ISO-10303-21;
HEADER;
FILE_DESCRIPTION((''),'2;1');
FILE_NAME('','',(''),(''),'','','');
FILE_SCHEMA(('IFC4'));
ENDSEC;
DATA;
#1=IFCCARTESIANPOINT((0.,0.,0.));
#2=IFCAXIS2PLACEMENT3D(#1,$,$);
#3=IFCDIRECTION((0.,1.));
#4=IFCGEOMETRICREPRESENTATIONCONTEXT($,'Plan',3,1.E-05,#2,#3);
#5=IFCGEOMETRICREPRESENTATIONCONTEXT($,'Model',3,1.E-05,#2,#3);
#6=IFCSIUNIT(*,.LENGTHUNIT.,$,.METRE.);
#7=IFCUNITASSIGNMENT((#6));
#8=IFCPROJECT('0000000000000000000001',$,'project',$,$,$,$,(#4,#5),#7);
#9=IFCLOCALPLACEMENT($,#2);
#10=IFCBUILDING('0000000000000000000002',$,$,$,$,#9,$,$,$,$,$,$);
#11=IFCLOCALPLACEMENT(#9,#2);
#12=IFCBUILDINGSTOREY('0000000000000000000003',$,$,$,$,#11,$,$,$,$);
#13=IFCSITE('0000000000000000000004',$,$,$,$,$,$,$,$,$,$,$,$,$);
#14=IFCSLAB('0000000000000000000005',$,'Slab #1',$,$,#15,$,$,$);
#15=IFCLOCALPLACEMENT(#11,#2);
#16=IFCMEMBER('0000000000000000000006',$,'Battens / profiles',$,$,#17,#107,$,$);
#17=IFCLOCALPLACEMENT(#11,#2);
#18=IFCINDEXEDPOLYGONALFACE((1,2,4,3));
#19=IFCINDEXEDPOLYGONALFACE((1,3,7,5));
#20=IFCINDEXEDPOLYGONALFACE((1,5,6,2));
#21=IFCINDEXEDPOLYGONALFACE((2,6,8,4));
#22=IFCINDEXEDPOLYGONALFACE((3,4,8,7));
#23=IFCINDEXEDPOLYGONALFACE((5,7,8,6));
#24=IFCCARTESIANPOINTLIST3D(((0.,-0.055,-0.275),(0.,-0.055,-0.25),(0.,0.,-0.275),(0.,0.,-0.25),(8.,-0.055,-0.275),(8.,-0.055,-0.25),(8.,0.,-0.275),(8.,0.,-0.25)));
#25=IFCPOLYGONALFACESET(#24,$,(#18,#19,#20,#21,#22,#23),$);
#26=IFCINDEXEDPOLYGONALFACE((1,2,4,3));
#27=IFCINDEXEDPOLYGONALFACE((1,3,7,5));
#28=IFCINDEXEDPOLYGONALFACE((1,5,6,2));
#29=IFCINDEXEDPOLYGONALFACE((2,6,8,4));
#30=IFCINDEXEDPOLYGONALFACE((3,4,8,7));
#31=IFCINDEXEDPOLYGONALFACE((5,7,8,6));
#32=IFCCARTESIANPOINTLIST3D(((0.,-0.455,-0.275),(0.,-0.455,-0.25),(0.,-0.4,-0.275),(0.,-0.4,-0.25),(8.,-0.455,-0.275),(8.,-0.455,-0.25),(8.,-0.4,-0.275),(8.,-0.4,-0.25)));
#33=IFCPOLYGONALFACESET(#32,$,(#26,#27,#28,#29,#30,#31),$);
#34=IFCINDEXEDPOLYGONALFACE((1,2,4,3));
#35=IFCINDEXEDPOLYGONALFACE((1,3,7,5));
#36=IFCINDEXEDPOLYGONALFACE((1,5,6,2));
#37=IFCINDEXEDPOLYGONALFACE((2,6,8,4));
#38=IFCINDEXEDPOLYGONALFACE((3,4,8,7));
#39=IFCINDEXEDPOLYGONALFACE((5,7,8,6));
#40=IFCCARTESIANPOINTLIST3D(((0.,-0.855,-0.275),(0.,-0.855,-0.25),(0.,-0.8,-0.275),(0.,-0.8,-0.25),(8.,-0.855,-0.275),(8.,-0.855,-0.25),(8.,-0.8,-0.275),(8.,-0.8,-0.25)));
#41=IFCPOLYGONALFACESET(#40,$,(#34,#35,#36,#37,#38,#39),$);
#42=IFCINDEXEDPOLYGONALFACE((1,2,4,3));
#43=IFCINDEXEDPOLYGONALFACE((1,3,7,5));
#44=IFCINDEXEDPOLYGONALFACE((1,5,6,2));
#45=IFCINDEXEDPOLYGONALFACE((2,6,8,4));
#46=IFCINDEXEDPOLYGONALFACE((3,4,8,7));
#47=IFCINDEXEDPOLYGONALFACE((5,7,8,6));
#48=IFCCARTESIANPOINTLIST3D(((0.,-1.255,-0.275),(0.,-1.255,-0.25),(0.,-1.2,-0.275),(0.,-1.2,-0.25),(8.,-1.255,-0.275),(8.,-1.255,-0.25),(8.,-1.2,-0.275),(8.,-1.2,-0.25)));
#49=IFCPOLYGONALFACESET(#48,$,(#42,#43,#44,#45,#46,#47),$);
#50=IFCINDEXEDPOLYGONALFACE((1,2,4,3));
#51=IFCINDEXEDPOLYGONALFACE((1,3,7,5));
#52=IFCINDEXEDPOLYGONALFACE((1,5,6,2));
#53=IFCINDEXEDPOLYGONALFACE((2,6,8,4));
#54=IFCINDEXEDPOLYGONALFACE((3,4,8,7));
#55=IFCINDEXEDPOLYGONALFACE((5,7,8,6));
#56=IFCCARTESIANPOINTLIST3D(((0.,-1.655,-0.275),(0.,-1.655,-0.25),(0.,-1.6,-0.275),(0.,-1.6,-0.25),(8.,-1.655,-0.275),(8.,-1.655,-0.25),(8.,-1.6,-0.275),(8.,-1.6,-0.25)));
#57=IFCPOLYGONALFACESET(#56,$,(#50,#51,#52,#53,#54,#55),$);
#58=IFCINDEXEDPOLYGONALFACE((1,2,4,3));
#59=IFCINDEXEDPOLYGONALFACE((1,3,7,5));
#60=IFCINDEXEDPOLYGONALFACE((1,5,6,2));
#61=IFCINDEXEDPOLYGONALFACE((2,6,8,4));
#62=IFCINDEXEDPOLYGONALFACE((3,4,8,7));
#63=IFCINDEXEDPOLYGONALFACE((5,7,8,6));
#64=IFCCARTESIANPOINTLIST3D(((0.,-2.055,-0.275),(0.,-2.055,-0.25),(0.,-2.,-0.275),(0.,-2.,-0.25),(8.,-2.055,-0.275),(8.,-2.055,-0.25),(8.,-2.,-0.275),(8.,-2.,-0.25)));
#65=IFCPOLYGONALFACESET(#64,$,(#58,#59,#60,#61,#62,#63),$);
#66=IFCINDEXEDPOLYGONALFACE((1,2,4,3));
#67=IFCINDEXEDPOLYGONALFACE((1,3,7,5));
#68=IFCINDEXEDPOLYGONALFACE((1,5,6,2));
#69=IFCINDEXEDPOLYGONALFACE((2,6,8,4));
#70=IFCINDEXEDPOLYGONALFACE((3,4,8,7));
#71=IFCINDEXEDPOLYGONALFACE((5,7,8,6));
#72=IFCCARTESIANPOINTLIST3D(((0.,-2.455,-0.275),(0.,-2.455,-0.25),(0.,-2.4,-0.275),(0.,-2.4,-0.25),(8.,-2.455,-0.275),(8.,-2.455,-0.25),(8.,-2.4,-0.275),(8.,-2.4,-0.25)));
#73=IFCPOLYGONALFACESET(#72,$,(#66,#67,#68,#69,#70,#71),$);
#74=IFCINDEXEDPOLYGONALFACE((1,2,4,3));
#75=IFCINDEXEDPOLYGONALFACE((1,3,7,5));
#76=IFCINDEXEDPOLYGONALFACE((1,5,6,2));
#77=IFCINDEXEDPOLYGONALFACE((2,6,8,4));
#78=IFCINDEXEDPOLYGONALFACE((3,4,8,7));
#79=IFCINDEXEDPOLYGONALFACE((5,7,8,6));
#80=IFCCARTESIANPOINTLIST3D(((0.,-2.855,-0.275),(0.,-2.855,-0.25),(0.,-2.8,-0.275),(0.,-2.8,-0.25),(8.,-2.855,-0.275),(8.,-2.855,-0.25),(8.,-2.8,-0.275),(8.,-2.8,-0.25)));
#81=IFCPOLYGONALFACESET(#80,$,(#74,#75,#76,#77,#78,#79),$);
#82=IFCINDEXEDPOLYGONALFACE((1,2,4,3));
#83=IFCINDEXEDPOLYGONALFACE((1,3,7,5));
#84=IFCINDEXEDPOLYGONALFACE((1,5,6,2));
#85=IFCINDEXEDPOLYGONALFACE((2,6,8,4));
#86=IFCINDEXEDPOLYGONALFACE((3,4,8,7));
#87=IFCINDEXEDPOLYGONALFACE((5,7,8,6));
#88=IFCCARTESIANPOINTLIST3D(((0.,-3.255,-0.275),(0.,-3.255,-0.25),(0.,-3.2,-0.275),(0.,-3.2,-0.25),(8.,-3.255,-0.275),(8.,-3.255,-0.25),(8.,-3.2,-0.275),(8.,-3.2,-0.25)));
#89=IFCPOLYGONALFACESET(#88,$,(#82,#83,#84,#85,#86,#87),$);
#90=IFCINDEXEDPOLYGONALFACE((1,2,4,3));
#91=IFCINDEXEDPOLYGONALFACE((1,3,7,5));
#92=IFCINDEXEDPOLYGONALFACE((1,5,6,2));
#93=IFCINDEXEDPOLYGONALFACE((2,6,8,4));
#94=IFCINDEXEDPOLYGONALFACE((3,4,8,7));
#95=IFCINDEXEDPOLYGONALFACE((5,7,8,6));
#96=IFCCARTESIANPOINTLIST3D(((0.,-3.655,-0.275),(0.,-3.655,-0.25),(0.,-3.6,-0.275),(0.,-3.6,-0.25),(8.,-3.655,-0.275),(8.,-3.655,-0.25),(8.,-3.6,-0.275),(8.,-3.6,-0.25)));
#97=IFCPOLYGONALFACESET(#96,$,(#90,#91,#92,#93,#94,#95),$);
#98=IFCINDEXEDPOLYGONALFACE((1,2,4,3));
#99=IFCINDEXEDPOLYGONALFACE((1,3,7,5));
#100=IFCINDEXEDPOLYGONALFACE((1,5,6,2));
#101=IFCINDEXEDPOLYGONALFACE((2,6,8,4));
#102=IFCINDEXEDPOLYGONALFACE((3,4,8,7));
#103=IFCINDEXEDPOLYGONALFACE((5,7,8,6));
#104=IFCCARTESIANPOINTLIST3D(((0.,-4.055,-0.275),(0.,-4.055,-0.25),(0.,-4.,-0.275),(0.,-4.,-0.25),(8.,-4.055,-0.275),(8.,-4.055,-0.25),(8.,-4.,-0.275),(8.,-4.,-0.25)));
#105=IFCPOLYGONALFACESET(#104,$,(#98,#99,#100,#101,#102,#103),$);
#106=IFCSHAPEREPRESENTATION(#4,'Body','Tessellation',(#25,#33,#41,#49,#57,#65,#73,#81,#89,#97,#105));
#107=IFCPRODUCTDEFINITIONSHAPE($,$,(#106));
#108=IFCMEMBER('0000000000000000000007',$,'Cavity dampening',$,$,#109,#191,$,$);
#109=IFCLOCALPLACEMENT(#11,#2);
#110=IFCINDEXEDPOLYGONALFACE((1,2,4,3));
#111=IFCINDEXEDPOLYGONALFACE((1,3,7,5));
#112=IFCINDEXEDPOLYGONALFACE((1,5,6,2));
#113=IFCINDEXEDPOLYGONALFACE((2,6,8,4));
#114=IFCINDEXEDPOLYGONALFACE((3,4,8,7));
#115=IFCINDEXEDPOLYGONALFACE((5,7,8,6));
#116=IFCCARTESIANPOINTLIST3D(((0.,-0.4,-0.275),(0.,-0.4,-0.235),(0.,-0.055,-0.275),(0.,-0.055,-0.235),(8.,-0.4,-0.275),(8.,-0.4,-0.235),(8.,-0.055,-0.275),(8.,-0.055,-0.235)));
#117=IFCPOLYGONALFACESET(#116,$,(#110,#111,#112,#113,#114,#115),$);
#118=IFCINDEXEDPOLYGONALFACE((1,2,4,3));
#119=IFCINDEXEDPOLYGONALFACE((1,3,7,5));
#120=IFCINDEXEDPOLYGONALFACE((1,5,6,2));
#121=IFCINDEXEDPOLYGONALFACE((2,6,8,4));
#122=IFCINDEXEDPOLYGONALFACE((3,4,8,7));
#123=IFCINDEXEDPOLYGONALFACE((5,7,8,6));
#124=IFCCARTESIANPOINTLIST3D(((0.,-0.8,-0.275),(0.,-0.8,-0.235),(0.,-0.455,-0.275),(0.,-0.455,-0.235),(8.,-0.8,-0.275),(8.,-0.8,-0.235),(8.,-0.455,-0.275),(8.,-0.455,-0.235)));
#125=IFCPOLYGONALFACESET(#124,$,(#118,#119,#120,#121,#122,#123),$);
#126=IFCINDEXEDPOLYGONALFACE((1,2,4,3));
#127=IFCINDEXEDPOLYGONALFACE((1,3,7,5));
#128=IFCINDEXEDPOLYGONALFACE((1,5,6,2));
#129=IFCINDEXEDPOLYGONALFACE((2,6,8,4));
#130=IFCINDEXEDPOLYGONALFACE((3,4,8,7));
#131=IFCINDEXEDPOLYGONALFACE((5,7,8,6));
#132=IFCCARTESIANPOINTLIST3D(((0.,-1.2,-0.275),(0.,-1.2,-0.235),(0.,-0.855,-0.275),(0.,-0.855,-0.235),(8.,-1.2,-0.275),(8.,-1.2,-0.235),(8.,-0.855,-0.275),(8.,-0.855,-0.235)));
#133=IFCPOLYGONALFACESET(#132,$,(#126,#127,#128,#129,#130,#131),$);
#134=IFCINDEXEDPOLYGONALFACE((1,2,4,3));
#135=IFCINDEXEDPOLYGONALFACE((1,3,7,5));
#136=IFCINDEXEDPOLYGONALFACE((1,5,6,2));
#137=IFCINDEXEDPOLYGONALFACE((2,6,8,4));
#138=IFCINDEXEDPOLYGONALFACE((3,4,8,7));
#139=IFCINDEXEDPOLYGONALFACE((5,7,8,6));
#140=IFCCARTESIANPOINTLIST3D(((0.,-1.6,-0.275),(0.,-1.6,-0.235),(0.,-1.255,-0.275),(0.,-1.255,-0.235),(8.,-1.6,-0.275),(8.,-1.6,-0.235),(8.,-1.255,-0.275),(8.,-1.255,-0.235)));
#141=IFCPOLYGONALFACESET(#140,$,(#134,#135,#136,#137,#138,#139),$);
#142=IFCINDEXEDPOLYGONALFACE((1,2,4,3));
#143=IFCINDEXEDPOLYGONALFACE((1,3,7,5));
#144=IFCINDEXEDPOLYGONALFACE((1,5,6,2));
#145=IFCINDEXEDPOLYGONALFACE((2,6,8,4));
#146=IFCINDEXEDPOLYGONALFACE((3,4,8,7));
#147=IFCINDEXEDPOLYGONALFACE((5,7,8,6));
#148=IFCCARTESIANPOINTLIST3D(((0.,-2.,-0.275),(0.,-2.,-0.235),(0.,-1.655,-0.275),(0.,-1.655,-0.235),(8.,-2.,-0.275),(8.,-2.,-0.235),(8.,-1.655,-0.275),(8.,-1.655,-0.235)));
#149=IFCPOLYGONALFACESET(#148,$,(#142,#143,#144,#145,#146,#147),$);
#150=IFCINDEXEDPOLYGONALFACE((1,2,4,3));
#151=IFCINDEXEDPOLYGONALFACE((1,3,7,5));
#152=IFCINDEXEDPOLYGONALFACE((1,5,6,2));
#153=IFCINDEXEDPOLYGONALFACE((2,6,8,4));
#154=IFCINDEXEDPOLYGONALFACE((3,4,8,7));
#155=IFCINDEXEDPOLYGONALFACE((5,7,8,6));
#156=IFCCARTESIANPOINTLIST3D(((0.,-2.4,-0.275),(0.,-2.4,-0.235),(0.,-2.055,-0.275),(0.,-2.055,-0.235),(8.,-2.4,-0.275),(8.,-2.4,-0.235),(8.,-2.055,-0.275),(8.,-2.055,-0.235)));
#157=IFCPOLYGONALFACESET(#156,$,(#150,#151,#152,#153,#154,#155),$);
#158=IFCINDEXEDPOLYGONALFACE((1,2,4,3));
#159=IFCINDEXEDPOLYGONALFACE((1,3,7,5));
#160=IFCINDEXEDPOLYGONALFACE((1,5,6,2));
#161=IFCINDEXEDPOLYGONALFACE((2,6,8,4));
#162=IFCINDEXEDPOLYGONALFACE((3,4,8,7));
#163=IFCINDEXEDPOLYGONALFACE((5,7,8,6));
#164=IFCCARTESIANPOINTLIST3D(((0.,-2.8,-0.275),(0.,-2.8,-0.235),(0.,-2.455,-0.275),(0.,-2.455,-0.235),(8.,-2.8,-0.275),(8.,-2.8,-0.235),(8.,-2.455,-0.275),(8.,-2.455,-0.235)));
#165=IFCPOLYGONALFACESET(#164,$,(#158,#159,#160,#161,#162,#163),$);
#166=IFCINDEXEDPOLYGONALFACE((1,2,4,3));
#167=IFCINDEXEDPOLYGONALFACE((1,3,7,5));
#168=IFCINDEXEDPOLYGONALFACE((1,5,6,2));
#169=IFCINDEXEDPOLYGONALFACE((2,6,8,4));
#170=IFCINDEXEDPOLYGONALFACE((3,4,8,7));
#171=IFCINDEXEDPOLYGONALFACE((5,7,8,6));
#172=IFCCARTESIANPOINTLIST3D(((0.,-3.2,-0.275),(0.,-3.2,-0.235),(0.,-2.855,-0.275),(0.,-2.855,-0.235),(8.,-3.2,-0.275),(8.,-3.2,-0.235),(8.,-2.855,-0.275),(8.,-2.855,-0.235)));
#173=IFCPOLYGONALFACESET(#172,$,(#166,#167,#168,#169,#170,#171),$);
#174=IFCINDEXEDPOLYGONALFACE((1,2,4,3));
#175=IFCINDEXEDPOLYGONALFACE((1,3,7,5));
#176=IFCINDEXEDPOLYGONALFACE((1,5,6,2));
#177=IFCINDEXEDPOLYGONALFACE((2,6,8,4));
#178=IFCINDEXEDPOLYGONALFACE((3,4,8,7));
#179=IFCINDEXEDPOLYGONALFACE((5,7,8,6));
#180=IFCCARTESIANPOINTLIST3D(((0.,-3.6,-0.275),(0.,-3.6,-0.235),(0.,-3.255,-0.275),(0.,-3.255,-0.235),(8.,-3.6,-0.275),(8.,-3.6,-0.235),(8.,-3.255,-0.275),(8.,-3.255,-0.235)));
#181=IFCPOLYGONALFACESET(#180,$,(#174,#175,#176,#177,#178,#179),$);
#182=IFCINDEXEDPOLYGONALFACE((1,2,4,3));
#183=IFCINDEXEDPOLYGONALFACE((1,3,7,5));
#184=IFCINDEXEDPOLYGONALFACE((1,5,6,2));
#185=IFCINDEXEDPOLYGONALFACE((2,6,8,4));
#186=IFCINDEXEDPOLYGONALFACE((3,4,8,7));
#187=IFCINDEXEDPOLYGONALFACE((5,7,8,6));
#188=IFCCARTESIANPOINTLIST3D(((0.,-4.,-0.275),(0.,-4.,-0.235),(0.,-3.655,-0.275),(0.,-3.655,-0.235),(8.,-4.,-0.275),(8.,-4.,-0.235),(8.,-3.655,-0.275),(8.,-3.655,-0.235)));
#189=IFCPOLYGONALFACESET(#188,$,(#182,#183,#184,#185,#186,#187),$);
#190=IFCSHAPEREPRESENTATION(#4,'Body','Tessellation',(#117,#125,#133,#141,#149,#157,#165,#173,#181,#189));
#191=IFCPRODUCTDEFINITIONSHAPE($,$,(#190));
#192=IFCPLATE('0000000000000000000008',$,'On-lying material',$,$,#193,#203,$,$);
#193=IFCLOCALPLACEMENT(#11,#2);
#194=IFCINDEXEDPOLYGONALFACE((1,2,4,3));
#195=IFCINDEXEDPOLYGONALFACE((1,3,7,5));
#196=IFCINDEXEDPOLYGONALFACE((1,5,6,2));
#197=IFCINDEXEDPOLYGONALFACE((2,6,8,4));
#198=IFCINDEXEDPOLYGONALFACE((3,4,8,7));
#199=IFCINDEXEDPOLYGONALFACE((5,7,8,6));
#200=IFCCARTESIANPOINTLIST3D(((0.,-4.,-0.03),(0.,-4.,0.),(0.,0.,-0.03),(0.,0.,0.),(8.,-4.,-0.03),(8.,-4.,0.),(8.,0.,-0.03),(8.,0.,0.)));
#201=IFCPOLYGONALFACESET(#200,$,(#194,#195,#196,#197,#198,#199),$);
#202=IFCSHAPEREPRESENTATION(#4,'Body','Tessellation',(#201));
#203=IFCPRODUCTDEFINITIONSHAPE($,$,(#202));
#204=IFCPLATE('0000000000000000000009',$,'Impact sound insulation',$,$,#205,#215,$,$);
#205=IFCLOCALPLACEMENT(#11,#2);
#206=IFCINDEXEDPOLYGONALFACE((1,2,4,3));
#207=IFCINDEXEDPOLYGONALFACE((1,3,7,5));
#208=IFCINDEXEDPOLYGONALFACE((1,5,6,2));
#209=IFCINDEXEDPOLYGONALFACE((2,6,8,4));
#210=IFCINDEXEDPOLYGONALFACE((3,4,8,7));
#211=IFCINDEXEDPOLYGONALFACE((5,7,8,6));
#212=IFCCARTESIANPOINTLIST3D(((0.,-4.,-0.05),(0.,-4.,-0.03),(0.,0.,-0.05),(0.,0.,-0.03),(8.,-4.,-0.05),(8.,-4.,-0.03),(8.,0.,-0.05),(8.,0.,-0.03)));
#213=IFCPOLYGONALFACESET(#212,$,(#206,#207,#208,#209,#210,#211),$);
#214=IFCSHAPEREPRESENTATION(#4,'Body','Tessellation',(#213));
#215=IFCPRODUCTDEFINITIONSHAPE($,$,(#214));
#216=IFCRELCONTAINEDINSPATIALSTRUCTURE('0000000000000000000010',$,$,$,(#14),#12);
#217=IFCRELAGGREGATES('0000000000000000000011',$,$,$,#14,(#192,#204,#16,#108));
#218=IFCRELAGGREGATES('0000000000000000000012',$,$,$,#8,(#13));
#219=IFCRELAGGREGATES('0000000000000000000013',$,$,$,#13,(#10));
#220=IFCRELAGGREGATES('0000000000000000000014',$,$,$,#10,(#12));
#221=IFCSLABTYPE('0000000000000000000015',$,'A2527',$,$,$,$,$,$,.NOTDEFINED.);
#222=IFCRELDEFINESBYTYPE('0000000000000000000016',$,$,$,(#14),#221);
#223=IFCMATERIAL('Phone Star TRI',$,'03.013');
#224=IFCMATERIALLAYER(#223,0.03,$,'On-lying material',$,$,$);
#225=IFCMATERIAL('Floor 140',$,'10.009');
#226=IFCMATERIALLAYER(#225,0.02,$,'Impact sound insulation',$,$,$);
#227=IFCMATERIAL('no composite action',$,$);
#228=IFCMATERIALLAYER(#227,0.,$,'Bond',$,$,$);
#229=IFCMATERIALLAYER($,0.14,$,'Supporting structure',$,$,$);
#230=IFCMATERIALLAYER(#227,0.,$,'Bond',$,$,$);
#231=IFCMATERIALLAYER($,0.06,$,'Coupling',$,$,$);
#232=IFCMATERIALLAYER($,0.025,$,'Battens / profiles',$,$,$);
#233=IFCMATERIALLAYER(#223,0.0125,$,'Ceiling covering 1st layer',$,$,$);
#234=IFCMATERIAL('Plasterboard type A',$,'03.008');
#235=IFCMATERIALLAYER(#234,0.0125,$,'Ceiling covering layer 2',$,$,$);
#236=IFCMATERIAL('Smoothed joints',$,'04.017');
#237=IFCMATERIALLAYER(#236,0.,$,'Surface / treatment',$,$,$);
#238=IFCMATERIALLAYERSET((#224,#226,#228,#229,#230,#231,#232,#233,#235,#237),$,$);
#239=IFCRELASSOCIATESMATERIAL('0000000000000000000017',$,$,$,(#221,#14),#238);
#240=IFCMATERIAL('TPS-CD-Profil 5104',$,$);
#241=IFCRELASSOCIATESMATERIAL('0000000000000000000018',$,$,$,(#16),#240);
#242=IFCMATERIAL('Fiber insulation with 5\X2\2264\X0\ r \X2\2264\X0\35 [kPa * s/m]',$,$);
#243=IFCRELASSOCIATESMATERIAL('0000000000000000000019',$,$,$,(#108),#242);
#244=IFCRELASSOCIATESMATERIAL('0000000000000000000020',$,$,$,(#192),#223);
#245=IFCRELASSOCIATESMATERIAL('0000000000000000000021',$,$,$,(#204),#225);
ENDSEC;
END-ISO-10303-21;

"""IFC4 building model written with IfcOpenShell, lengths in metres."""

from ifc_helpers import new_model, si_unit, direction, frame, frame_2d, origin, origin_with_axes, place, context, project, spatial, rectangle, extrude, material, layer, layer_set, type_object, element, aggregate, save


model = new_model("IFC4")

# Units and contexts
plan_context = context("Plan", 3, precision=1e-05, world=origin(), true_north=direction((0.0, 1.0)))
model_context = context("Model", 3, precision=1e-05, world=origin(), true_north=direction((0.0, 1.0)))
ifc_project = project(units=[si_unit("LENGTHUNIT", "METRE")], contexts=[plan_context, model_context])

# Site, building, storey
site = spatial("IfcSite", under=ifc_project)
building_placement = place(None, origin())
building = spatial("IfcBuilding", under=site, at=building_placement)
storey_placement = place(building_placement, origin())
storey = spatial("IfcBuildingStorey", under=building, at=storey_placement)

# Slab, members, plates
ifc_material_1 = material(Name="Phone Star TRI", Category="03.013")
ifc_layer_1 = layer(ifc_material_1, 0.03, Name="On-lying material")
ifc_material_2 = material(Name="Floor 140", Category="10.009")
ifc_layer_2 = layer(ifc_material_2, 0.02, Name="Impact sound insulation")
ifc_material_3 = material(Name="no composite action")
ifc_layer_3 = layer(ifc_material_3, 0.0, Name="Bond")
ifc_layer_4 = layer(None, 0.14, Name="Supporting structure")
ifc_layer_5 = layer(ifc_material_3, 0.0, Name="Bond")
ifc_layer_6 = layer(None, 0.06, Name="Coupling")
ifc_layer_7 = layer(None, 0.025, Name="Battens / profiles")
ifc_layer_8 = layer(ifc_material_1, 0.0125, Name="Ceiling covering 1st layer")
ifc_material_4 = material(Name="Plasterboard type A", Category="03.008")
ifc_layer_9 = layer(ifc_material_4, 0.0125, Name="Ceiling covering layer 2")
ifc_material_5 = material(Name="Smoothed joints", Category="04.017")
ifc_layer_10 = layer(ifc_material_5, 0.0, Name="Surface / treatment")
ifc_layer_set = layer_set([ifc_layer_1, ifc_layer_2, ifc_layer_3, ifc_layer_4, ifc_layer_5, ifc_layer_6, ifc_layer_7, ifc_layer_8, ifc_layer_9, ifc_layer_10])
slab_type = type_object("IfcSlabType", Name="A2527", PredefinedType="NOTDEFINED", material=ifc_layer_set)
slab_placement = place(None, frame((0.0, 0.0, 0.0), z_axis=(0.0, 0.0, -1.0), x_axis=(1.0, 0.0, 0.0)))
slab = element("IfcSlab", 1, at=slab_placement, inside=storey, type_object=slab_type, material=ifc_layer_set, Name="Slab #1")
ifc_material_6 = material(Name="TPS-CD-Profil 5104")
member_1_placement = place(slab_placement, origin())
member_1 = element("IfcMember", 2, at=member_1_placement, material=ifc_material_6, Name="Battens / profiles", context=plan_context, shape_type="SweptSolid", body=[
    extrude(rectangle(XDim=0.055, YDim=0.025, at=frame_2d((0.0275, 0.0125), x_axis=(1.0, 0.0))), frame((0.0, 0.0, 0.25), z_axis=(1.0, 0.0, 0.0), x_axis=(0.0, 1.0, 0.0)), (0.0, 0.0, 1.0), 8.0),
    extrude(rectangle(XDim=0.055, YDim=0.025, at=frame_2d((0.0275, 0.0125), x_axis=(1.0, 0.0))), frame((0.0, 0.4, 0.25), z_axis=(1.0, 0.0, 0.0), x_axis=(0.0, 1.0, 0.0)), (0.0, 0.0, 1.0), 8.0),
    extrude(rectangle(XDim=0.055, YDim=0.025, at=frame_2d((0.0275, 0.0125), x_axis=(1.0, 0.0))), frame((0.0, 0.8, 0.25), z_axis=(1.0, 0.0, 0.0), x_axis=(0.0, 1.0, 0.0)), (0.0, 0.0, 1.0), 8.0),
    extrude(rectangle(XDim=0.055, YDim=0.025, at=frame_2d((0.0275, 0.0125), x_axis=(1.0, 0.0))), frame((0.0, 1.2, 0.25), z_axis=(1.0, 0.0, 0.0), x_axis=(0.0, 1.0, 0.0)), (0.0, 0.0, 1.0), 8.0),
    extrude(rectangle(XDim=0.055, YDim=0.025, at=frame_2d((0.0275, 0.0125), x_axis=(1.0, 0.0))), frame((0.0, 1.6, 0.25), z_axis=(1.0, 0.0, 0.0), x_axis=(0.0, 1.0, 0.0)), (0.0, 0.0, 1.0), 8.0),
    extrude(rectangle(XDim=0.055, YDim=0.025, at=frame_2d((0.0275, 0.0125), x_axis=(1.0, 0.0))), frame((0.0, 2.0, 0.25), z_axis=(1.0, 0.0, 0.0), x_axis=(0.0, 1.0, 0.0)), (0.0, 0.0, 1.0), 8.0),
    extrude(rectangle(XDim=0.055, YDim=0.025, at=frame_2d((0.0275, 0.0125), x_axis=(1.0, 0.0))), frame((0.0, 2.4, 0.25), z_axis=(1.0, 0.0, 0.0), x_axis=(0.0, 1.0, 0.0)), (0.0, 0.0, 1.0), 8.0),
    extrude(rectangle(XDim=0.055, YDim=0.025, at=frame_2d((0.0275, 0.0125), x_axis=(1.0, 0.0))), frame((0.0, 2.8, 0.25), z_axis=(1.0, 0.0, 0.0), x_axis=(0.0, 1.0, 0.0)), (0.0, 0.0, 1.0), 8.0),
    extrude(rectangle(XDim=0.055, YDim=0.025, at=frame_2d((0.0275, 0.0125), x_axis=(1.0, 0.0))), frame((0.0, 3.2, 0.25), z_axis=(1.0, 0.0, 0.0), x_axis=(0.0, 1.0, 0.0)), (0.0, 0.0, 1.0), 8.0),
    extrude(rectangle(XDim=0.055, YDim=0.025, at=frame_2d((0.0275, 0.0125), x_axis=(1.0, 0.0))), frame((0.0, 3.6, 0.25), z_axis=(1.0, 0.0, 0.0), x_axis=(0.0, 1.0, 0.0)), (0.0, 0.0, 1.0), 8.0),
    extrude(rectangle(XDim=0.055, YDim=0.025, at=frame_2d((0.0275, 0.0125), x_axis=(1.0, 0.0))), frame((0.0, 4.0, 0.25), z_axis=(1.0, 0.0, 0.0), x_axis=(0.0, 1.0, 0.0)), (0.0, 0.0, 1.0), 8.0),
])
ifc_material_7 = material(Name="Fiber insulation with 5≤ r ≤35 [kPa * s/m]")
member_2_placement = place(slab_placement, origin())
member_2 = element("IfcMember", 3, at=member_2_placement, material=ifc_material_7, Name="Cavity dampening", context=plan_context, shape_type="SweptSolid", body=[
    extrude(rectangle(XDim=0.345, YDim=0.04, at=frame_2d((0.1725, 0.02), x_axis=(1.0, 0.0))), frame((0.0, 0.055, 0.235), z_axis=(1.0, 0.0, 0.0), x_axis=(0.0, 1.0, 0.0)), (0.0, 0.0, 1.0), 8.0),
    extrude(rectangle(XDim=0.345, YDim=0.04, at=frame_2d((0.1725, 0.02), x_axis=(1.0, 0.0))), frame((0.0, 0.455, 0.235), z_axis=(1.0, 0.0, 0.0), x_axis=(0.0, 1.0, 0.0)), (0.0, 0.0, 1.0), 8.0),
    extrude(rectangle(XDim=0.345, YDim=0.04, at=frame_2d((0.1725, 0.02), x_axis=(1.0, 0.0))), frame((0.0, 0.855, 0.235), z_axis=(1.0, 0.0, 0.0), x_axis=(0.0, 1.0, 0.0)), (0.0, 0.0, 1.0), 8.0),
    extrude(rectangle(XDim=0.345, YDim=0.04, at=frame_2d((0.1725, 0.02), x_axis=(1.0, 0.0))), frame((0.0, 1.255, 0.235), z_axis=(1.0, 0.0, 0.0), x_axis=(0.0, 1.0, 0.0)), (0.0, 0.0, 1.0), 8.0),
    extrude(rectangle(XDim=0.345, YDim=0.04, at=frame_2d((0.1725, 0.02), x_axis=(1.0, 0.0))), frame((0.0, 1.655, 0.235), z_axis=(1.0, 0.0, 0.0), x_axis=(0.0, 1.0, 0.0)), (0.0, 0.0, 1.0), 8.0),
    extrude(rectangle(XDim=0.345, YDim=0.04, at=frame_2d((0.1725, 0.02), x_axis=(1.0, 0.0))), frame((0.0, 2.055, 0.235), z_axis=(1.0, 0.0, 0.0), x_axis=(0.0, 1.0, 0.0)), (0.0, 0.0, 1.0), 8.0),
    extrude(rectangle(XDim=0.345, YDim=0.04, at=frame_2d((0.1725, 0.02), x_axis=(1.0, 0.0))), frame((0.0, 2.455, 0.235), z_axis=(1.0, 0.0, 0.0), x_axis=(0.0, 1.0, 0.0)), (0.0, 0.0, 1.0), 8.0),
    extrude(rectangle(XDim=0.345, YDim=0.04, at=frame_2d((0.1725, 0.02), x_axis=(1.0, 0.0))), frame((0.0, 2.855, 0.235), z_axis=(1.0, 0.0, 0.0), x_axis=(0.0, 1.0, 0.0)), (0.0, 0.0, 1.0), 8.0),
    extrude(rectangle(XDim=0.345, YDim=0.04, at=frame_2d((0.1725, 0.02), x_axis=(1.0, 0.0))), frame((0.0, 3.255, 0.235), z_axis=(1.0, 0.0, 0.0), x_axis=(0.0, 1.0, 0.0)), (0.0, 0.0, 1.0), 8.0),
    extrude(rectangle(XDim=0.345, YDim=0.04, at=frame_2d((0.1725, 0.02), x_axis=(1.0, 0.0))), frame((0.0, 3.655, 0.235), z_axis=(1.0, 0.0, 0.0), x_axis=(0.0, 1.0, 0.0)), (0.0, 0.0, 1.0), 8.0),
])
plate_1_placement = place(slab_placement, origin())
plate_1 = element("IfcPlate", 4, at=plate_1_placement, material=ifc_material_1, Name="On-lying material", context=plan_context, shape_type="SweptSolid", body=[
    extrude(rectangle(XDim=8.0, YDim=4.0, at=frame_2d((4.0, 2.0), x_axis=(1.0, 0.0))), origin_with_axes(), (0.0, 0.0, 1.0), 0.03),
])
plate_2_placement = place(slab_placement, origin())
plate_2 = element("IfcPlate", 5, at=plate_2_placement, material=ifc_material_2, Name="Impact sound insulation", context=plan_context, shape_type="SweptSolid", body=[
    extrude(rectangle(XDim=8.0, YDim=4.0, at=frame_2d((4.0, 2.0), x_axis=(1.0, 0.0))), frame((0.0, 0.0, 0.03), z_axis=(0.0, 0.0, 1.0), x_axis=(1.0, 0.0, 0.0)), (0.0, 0.0, 1.0), 0.02),
])
aggregate(slab, [plate_1, plate_2, member_1, member_2])

save(model, "model.ifc")
